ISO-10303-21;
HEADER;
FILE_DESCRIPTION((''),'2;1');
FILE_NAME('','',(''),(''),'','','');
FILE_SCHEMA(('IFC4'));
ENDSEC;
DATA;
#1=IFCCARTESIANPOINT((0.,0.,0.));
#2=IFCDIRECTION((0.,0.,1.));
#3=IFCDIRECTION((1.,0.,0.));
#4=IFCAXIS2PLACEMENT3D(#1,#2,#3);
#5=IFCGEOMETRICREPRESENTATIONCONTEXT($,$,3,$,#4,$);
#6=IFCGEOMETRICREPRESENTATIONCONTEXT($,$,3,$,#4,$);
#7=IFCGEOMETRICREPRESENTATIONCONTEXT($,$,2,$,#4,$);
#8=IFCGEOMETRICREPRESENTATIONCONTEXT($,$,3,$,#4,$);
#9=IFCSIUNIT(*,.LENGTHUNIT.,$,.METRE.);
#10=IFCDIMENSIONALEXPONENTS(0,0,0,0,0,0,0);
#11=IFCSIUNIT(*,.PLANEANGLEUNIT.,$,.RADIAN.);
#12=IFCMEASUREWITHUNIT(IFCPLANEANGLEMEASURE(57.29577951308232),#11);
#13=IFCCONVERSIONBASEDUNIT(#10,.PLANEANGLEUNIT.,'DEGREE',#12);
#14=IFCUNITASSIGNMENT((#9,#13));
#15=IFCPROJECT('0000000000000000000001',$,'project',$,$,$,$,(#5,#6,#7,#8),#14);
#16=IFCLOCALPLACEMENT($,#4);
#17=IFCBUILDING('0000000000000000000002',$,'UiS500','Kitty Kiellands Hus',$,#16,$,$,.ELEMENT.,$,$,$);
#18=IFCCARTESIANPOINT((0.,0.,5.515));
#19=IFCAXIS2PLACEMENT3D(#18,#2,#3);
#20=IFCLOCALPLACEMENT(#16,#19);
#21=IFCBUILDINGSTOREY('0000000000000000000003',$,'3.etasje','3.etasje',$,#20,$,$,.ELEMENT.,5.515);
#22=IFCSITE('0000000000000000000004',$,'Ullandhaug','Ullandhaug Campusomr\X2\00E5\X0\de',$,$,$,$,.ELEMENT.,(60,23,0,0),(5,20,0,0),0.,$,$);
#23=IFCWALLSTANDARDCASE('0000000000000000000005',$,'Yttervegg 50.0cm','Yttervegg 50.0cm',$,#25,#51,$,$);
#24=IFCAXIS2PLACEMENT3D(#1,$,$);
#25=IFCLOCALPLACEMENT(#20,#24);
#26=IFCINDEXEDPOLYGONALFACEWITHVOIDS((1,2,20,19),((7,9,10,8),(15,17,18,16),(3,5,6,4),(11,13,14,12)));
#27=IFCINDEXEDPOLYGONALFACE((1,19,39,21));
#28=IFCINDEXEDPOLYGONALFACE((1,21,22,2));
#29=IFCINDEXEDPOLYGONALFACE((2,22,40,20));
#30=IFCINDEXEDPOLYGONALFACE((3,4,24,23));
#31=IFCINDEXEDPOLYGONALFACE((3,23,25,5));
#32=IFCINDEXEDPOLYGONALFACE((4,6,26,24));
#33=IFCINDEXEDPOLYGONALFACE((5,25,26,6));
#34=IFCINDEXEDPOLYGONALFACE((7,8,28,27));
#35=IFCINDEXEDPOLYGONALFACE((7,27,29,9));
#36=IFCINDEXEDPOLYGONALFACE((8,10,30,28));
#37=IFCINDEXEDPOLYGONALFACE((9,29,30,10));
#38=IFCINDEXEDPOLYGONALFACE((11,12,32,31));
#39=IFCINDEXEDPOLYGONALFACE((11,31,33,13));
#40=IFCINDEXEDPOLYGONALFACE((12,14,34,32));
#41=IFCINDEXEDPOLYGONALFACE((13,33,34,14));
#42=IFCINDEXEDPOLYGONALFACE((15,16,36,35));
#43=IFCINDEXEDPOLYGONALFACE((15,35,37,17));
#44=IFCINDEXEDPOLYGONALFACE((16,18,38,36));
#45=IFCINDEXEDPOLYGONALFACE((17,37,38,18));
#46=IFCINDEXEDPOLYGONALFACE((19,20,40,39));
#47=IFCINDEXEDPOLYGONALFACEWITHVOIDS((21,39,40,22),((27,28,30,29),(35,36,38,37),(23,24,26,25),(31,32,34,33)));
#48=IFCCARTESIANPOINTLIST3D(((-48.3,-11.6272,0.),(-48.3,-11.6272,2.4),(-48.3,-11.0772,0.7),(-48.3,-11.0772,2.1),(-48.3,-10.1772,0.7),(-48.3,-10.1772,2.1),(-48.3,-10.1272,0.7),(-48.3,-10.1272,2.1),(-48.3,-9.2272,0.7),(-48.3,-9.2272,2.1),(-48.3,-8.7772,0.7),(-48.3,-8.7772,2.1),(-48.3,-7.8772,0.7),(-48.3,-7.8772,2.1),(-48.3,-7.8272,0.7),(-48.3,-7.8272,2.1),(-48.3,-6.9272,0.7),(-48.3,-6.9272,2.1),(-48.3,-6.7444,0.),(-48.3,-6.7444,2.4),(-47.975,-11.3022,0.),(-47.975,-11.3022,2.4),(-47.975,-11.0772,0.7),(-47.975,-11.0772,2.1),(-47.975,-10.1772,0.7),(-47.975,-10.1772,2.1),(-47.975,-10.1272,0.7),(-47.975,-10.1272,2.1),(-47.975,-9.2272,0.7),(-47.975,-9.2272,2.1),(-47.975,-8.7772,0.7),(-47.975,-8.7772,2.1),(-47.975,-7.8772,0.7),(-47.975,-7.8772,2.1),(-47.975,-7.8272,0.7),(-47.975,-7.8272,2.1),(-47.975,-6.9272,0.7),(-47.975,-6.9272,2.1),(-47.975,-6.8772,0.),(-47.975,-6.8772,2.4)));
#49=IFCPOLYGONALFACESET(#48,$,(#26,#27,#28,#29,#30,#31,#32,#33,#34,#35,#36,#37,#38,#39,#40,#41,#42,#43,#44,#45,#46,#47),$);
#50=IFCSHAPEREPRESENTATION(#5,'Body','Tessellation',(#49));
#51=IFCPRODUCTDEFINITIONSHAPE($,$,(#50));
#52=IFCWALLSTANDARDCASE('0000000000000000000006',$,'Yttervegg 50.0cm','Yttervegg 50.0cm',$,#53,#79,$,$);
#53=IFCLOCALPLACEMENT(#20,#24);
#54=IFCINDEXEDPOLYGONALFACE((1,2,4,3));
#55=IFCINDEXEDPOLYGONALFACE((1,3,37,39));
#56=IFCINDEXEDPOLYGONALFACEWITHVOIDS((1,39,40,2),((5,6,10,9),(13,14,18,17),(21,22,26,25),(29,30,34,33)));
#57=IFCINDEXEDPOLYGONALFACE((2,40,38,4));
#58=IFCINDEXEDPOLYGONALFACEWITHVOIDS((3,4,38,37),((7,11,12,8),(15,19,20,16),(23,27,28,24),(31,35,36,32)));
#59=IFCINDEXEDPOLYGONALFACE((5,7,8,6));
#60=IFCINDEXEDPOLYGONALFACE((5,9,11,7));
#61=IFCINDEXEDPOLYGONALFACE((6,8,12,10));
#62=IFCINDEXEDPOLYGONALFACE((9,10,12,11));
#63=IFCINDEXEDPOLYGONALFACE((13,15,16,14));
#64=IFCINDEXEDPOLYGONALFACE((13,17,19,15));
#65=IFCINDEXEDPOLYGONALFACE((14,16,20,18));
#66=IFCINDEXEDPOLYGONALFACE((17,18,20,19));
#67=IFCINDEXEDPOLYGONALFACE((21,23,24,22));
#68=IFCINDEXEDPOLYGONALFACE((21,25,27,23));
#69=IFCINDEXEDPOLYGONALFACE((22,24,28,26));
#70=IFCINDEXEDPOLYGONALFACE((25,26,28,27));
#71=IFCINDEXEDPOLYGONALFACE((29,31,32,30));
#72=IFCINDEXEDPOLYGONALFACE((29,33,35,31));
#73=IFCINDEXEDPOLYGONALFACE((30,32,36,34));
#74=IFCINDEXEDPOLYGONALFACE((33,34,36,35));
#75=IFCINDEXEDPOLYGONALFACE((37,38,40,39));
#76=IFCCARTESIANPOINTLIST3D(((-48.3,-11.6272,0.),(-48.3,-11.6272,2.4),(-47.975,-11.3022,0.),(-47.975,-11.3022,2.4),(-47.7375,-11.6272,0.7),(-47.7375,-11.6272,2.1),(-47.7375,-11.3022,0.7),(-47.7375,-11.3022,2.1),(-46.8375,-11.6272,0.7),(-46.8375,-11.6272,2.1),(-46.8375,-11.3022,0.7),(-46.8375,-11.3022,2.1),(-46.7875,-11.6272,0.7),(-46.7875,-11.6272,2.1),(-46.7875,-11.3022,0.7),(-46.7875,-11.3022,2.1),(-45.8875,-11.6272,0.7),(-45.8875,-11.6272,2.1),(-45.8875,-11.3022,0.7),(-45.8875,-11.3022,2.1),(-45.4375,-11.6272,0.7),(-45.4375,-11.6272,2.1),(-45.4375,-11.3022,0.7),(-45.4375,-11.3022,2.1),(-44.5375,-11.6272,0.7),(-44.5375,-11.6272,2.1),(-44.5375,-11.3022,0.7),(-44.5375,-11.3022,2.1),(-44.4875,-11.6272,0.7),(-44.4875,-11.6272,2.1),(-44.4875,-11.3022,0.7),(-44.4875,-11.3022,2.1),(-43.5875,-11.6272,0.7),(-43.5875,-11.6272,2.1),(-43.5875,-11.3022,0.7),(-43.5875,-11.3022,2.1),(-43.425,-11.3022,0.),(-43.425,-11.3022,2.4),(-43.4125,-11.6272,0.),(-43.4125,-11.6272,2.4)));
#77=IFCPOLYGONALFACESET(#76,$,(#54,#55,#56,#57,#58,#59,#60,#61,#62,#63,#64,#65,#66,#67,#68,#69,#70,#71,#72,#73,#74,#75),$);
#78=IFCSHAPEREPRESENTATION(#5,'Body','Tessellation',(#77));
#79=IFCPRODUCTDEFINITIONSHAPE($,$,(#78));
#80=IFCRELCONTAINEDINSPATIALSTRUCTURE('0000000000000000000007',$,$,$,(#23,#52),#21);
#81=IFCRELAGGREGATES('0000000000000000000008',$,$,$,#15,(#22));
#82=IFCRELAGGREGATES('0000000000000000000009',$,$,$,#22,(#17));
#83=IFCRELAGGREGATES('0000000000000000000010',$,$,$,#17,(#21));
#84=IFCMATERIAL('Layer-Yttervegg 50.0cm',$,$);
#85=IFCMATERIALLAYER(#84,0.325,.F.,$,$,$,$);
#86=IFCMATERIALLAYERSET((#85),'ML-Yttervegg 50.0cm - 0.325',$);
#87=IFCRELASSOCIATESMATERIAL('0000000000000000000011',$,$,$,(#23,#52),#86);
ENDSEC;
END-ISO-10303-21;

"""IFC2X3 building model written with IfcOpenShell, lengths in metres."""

from ifc_helpers import new_model, entity, si_unit, converted_unit, frame, origin_with_axes, place, context, project, spatial, polyline, outline, extrude, material, layer, layer_set, layer_usage, element, save


model = new_model("IFC2X3")

# Units and contexts
context_of_model_1 = context(None, 3, world=origin_with_axes())
context_of_model_2 = context(None, 3, world=origin_with_axes())
context_of_model_3 = context(None, 2, world=origin_with_axes())
context_of_model_4 = context(None, 3, world=origin_with_axes())
ifc_project = project(units=[si_unit("LENGTHUNIT", "METRE"), converted_unit("PLANEANGLEUNIT", "DEGREE", entity("IfcPlaneAngleMeasure", 57.29577951308232), si_unit("PLANEANGLEUNIT", "RADIAN"), dimensions=[0, 0, 0, 0, 0, 0, 0])], contexts=[context_of_model_1, context_of_model_2, context_of_model_3, context_of_model_4])

# Site, building, storey
site = spatial("IfcSite", under=ifc_project, Name="Ullandhaug", Description="Ullandhaug Campusområde", CompositionType="ELEMENT", RefLatitude=(60, 23, 0, 0), RefLongitude=(5, 20, 0, 0), RefElevation=0.0)
building_placement = place(None, origin_with_axes())
building = spatial("IfcBuilding", under=site, at=building_placement, Name="UiS500", Description="Kitty Kiellands Hus", CompositionType="ELEMENT")
storey_placement = place(building_placement, frame((0.0, 0.0, 5.515), z_axis=(0.0, 0.0, 1.0), x_axis=(1.0, 0.0, 0.0)))
storey = spatial("IfcBuildingStorey", under=building, at=storey_placement, Name="3.etasje", Description="3.etasje", CompositionType="ELEMENT", Elevation=5.515)

# Shared definitions
ifc_material_1 = material(Name="Layer-Yttervegg 50.0cm")
ifc_layer_1 = layer(ifc_material_1, 0.325, ventilated=False)
ifc_layer_set_1 = layer_set([ifc_layer_1], Name="ML-Yttervegg 50.0cm - 0.325")
ifc_layer_usage_1 = layer_usage(ifc_layer_set_1, "AXIS2", "POSITIVE", 0.0)

# Walls, openings
wall_1_placement = place(storey_placement, frame((-48.3, -6.7444, 0.0), z_axis=(0.0, 0.0, 1.0), x_axis=(0.0, -1.0, 0.0)))
wall_1 = element("IfcWallStandardCase", 1, at=wall_1_placement, inside=storey, material=ifc_layer_usage_1, Name="Yttervegg 50.0cm", Description="Yttervegg 50.0cm", context=context_of_model_1, shape_type="SweptSolid", body=[
    extrude(outline(polyline([(0.0, 0.0), (4.8828, 0.0), (4.5578, 0.325), (0.1328, 0.325), (0.0, 0.0)])), frame((0.0, 0.0, 0.0), z_axis=(0.0, 0.0, 1.0), x_axis=(1.0, 0.0, 0.0)), (0.0, 0.0, 1.0), 2.4),
])
opening_1_placement = place(wall_1_placement, frame((0.1828, 0.325, 0.7), z_axis=(0.0, 0.0, 1.0), x_axis=(1.0, 0.0, 0.0)))
element("IfcOpeningElement", 2, at=opening_1_placement, cuts=wall_1, context=context_of_model_1, shape_type="SweptSolid", body=[
    extrude(outline(polyline([(0.0, 0.0), (1.4, 0.0), (1.4, 0.9), (0.0, 0.9), (0.0, 0.0)])), frame((0.0, 0.0, 0.0), z_axis=(0.0, 1.0, 0.0), x_axis=(0.0, 0.0, 1.0)), (0.0, 0.0, -1.0), 0.325),
])
opening_2_placement = place(wall_1_placement, frame((1.1328, 0.325, 0.7), z_axis=(0.0, 0.0, 1.0), x_axis=(1.0, 0.0, 0.0)))
element("IfcOpeningElement", 3, at=opening_2_placement, cuts=wall_1, context=context_of_model_1, shape_type="SweptSolid", body=[
    extrude(outline(polyline([(0.0, 0.0), (1.4, 0.0), (1.4, 0.9), (0.0, 0.9), (0.0, 0.0)])), frame((0.0, 0.0, 0.0), z_axis=(0.0, 1.0, 0.0), x_axis=(0.0, 0.0, 1.0)), (0.0, 0.0, -1.0), 0.325),
])
opening_3_placement = place(wall_1_placement, frame((2.4828, 0.325, 0.7), z_axis=(0.0, 0.0, 1.0), x_axis=(1.0, 0.0, 0.0)))
element("IfcOpeningElement", 4, at=opening_3_placement, cuts=wall_1, context=context_of_model_1, shape_type="SweptSolid", body=[
    extrude(outline(polyline([(0.0, 0.0), (1.4, 0.0), (1.4, 0.9), (0.0, 0.9), (0.0, 0.0)])), frame((0.0, 0.0, 0.0), z_axis=(0.0, 1.0, 0.0), x_axis=(0.0, 0.0, 1.0)), (0.0, 0.0, -1.0), 0.325),
])
opening_4_placement = place(wall_1_placement, frame((3.4328, 0.325, 0.7), z_axis=(0.0, 0.0, 1.0), x_axis=(1.0, 0.0, 0.0)))
element("IfcOpeningElement", 5, at=opening_4_placement, cuts=wall_1, context=context_of_model_1, shape_type="SweptSolid", body=[
    extrude(outline(polyline([(0.0, 0.0), (1.4, 0.0), (1.4, 0.9), (0.0, 0.9), (0.0, 0.0)])), frame((0.0, 0.0, 0.0), z_axis=(0.0, 1.0, 0.0), x_axis=(0.0, 0.0, 1.0)), (0.0, 0.0, -1.0), 0.325),
])
wall_2_placement = place(storey_placement, frame((-48.3, -11.6272, 0.0), z_axis=(0.0, 0.0, 1.0), x_axis=(1.0, 0.0, 0.0)))
wall_2 = element("IfcWallStandardCase", 6, at=wall_2_placement, inside=storey, material=ifc_layer_usage_1, Name="Yttervegg 50.0cm", Description="Yttervegg 50.0cm", context=context_of_model_1, shape_type="SweptSolid", body=[
    extrude(outline(polyline([(0.0, 0.0), (4.8875, 0.0), (4.875, 0.325), (0.325, 0.325), (0.0, 0.0)])), origin_with_axes(), (0.0, 0.0, 1.0), 2.4),
])
opening_5_placement = place(wall_2_placement, frame((0.5625, 0.325, 0.7), z_axis=(0.0, 0.0, 1.0), x_axis=(1.0, 0.0, 0.0)))
element("IfcOpeningElement", 7, at=opening_5_placement, cuts=wall_2, context=context_of_model_1, shape_type="SweptSolid", body=[
    extrude(outline(polyline([(0.0, 0.0), (1.4, 0.0), (1.4, 0.9), (0.0, 0.9), (0.0, 0.0)])), frame((0.0, 0.0, 0.0), z_axis=(0.0, 1.0, 0.0), x_axis=(0.0, 0.0, 1.0)), (0.0, 0.0, -1.0), 0.325),
])
opening_6_placement = place(wall_2_placement, frame((1.5125, 0.325, 0.7), z_axis=(0.0, 0.0, 1.0), x_axis=(1.0, 0.0, 0.0)))
element("IfcOpeningElement", 8, at=opening_6_placement, cuts=wall_2, context=context_of_model_1, shape_type="SweptSolid", body=[
    extrude(outline(polyline([(0.0, 0.0), (1.4, 0.0), (1.4, 0.9), (0.0, 0.9), (0.0, 0.0)])), frame((0.0, 0.0, 0.0), z_axis=(0.0, 1.0, 0.0), x_axis=(0.0, 0.0, 1.0)), (0.0, 0.0, -1.0), 0.325),
])
opening_7_placement = place(wall_2_placement, frame((2.8625, 0.325, 0.7), z_axis=(0.0, 0.0, 1.0), x_axis=(1.0, 0.0, 0.0)))
element("IfcOpeningElement", 9, at=opening_7_placement, cuts=wall_2, context=context_of_model_1, shape_type="SweptSolid", body=[
    extrude(outline(polyline([(0.0, 0.0), (1.4, 0.0), (1.4, 0.9), (0.0, 0.9), (0.0, 0.0)])), frame((0.0, 0.0, 0.0), z_axis=(0.0, 1.0, 0.0), x_axis=(0.0, 0.0, 1.0)), (0.0, 0.0, -1.0), 0.325),
])
opening_8_placement = place(wall_2_placement, frame((3.8125, 0.325, 0.7), z_axis=(0.0, 0.0, 1.0), x_axis=(1.0, 0.0, 0.0)))
element("IfcOpeningElement", 10, at=opening_8_placement, cuts=wall_2, context=context_of_model_1, shape_type="SweptSolid", body=[
    extrude(outline(polyline([(0.0, 0.0), (1.4, 0.0), (1.4, 0.9), (0.0, 0.9), (0.0, 0.0)])), frame((0.0, 0.0, 0.0), z_axis=(0.0, 1.0, 0.0), x_axis=(0.0, 0.0, 1.0)), (0.0, 0.0, -1.0), 0.325),
])

save(model, "model.ifc")
